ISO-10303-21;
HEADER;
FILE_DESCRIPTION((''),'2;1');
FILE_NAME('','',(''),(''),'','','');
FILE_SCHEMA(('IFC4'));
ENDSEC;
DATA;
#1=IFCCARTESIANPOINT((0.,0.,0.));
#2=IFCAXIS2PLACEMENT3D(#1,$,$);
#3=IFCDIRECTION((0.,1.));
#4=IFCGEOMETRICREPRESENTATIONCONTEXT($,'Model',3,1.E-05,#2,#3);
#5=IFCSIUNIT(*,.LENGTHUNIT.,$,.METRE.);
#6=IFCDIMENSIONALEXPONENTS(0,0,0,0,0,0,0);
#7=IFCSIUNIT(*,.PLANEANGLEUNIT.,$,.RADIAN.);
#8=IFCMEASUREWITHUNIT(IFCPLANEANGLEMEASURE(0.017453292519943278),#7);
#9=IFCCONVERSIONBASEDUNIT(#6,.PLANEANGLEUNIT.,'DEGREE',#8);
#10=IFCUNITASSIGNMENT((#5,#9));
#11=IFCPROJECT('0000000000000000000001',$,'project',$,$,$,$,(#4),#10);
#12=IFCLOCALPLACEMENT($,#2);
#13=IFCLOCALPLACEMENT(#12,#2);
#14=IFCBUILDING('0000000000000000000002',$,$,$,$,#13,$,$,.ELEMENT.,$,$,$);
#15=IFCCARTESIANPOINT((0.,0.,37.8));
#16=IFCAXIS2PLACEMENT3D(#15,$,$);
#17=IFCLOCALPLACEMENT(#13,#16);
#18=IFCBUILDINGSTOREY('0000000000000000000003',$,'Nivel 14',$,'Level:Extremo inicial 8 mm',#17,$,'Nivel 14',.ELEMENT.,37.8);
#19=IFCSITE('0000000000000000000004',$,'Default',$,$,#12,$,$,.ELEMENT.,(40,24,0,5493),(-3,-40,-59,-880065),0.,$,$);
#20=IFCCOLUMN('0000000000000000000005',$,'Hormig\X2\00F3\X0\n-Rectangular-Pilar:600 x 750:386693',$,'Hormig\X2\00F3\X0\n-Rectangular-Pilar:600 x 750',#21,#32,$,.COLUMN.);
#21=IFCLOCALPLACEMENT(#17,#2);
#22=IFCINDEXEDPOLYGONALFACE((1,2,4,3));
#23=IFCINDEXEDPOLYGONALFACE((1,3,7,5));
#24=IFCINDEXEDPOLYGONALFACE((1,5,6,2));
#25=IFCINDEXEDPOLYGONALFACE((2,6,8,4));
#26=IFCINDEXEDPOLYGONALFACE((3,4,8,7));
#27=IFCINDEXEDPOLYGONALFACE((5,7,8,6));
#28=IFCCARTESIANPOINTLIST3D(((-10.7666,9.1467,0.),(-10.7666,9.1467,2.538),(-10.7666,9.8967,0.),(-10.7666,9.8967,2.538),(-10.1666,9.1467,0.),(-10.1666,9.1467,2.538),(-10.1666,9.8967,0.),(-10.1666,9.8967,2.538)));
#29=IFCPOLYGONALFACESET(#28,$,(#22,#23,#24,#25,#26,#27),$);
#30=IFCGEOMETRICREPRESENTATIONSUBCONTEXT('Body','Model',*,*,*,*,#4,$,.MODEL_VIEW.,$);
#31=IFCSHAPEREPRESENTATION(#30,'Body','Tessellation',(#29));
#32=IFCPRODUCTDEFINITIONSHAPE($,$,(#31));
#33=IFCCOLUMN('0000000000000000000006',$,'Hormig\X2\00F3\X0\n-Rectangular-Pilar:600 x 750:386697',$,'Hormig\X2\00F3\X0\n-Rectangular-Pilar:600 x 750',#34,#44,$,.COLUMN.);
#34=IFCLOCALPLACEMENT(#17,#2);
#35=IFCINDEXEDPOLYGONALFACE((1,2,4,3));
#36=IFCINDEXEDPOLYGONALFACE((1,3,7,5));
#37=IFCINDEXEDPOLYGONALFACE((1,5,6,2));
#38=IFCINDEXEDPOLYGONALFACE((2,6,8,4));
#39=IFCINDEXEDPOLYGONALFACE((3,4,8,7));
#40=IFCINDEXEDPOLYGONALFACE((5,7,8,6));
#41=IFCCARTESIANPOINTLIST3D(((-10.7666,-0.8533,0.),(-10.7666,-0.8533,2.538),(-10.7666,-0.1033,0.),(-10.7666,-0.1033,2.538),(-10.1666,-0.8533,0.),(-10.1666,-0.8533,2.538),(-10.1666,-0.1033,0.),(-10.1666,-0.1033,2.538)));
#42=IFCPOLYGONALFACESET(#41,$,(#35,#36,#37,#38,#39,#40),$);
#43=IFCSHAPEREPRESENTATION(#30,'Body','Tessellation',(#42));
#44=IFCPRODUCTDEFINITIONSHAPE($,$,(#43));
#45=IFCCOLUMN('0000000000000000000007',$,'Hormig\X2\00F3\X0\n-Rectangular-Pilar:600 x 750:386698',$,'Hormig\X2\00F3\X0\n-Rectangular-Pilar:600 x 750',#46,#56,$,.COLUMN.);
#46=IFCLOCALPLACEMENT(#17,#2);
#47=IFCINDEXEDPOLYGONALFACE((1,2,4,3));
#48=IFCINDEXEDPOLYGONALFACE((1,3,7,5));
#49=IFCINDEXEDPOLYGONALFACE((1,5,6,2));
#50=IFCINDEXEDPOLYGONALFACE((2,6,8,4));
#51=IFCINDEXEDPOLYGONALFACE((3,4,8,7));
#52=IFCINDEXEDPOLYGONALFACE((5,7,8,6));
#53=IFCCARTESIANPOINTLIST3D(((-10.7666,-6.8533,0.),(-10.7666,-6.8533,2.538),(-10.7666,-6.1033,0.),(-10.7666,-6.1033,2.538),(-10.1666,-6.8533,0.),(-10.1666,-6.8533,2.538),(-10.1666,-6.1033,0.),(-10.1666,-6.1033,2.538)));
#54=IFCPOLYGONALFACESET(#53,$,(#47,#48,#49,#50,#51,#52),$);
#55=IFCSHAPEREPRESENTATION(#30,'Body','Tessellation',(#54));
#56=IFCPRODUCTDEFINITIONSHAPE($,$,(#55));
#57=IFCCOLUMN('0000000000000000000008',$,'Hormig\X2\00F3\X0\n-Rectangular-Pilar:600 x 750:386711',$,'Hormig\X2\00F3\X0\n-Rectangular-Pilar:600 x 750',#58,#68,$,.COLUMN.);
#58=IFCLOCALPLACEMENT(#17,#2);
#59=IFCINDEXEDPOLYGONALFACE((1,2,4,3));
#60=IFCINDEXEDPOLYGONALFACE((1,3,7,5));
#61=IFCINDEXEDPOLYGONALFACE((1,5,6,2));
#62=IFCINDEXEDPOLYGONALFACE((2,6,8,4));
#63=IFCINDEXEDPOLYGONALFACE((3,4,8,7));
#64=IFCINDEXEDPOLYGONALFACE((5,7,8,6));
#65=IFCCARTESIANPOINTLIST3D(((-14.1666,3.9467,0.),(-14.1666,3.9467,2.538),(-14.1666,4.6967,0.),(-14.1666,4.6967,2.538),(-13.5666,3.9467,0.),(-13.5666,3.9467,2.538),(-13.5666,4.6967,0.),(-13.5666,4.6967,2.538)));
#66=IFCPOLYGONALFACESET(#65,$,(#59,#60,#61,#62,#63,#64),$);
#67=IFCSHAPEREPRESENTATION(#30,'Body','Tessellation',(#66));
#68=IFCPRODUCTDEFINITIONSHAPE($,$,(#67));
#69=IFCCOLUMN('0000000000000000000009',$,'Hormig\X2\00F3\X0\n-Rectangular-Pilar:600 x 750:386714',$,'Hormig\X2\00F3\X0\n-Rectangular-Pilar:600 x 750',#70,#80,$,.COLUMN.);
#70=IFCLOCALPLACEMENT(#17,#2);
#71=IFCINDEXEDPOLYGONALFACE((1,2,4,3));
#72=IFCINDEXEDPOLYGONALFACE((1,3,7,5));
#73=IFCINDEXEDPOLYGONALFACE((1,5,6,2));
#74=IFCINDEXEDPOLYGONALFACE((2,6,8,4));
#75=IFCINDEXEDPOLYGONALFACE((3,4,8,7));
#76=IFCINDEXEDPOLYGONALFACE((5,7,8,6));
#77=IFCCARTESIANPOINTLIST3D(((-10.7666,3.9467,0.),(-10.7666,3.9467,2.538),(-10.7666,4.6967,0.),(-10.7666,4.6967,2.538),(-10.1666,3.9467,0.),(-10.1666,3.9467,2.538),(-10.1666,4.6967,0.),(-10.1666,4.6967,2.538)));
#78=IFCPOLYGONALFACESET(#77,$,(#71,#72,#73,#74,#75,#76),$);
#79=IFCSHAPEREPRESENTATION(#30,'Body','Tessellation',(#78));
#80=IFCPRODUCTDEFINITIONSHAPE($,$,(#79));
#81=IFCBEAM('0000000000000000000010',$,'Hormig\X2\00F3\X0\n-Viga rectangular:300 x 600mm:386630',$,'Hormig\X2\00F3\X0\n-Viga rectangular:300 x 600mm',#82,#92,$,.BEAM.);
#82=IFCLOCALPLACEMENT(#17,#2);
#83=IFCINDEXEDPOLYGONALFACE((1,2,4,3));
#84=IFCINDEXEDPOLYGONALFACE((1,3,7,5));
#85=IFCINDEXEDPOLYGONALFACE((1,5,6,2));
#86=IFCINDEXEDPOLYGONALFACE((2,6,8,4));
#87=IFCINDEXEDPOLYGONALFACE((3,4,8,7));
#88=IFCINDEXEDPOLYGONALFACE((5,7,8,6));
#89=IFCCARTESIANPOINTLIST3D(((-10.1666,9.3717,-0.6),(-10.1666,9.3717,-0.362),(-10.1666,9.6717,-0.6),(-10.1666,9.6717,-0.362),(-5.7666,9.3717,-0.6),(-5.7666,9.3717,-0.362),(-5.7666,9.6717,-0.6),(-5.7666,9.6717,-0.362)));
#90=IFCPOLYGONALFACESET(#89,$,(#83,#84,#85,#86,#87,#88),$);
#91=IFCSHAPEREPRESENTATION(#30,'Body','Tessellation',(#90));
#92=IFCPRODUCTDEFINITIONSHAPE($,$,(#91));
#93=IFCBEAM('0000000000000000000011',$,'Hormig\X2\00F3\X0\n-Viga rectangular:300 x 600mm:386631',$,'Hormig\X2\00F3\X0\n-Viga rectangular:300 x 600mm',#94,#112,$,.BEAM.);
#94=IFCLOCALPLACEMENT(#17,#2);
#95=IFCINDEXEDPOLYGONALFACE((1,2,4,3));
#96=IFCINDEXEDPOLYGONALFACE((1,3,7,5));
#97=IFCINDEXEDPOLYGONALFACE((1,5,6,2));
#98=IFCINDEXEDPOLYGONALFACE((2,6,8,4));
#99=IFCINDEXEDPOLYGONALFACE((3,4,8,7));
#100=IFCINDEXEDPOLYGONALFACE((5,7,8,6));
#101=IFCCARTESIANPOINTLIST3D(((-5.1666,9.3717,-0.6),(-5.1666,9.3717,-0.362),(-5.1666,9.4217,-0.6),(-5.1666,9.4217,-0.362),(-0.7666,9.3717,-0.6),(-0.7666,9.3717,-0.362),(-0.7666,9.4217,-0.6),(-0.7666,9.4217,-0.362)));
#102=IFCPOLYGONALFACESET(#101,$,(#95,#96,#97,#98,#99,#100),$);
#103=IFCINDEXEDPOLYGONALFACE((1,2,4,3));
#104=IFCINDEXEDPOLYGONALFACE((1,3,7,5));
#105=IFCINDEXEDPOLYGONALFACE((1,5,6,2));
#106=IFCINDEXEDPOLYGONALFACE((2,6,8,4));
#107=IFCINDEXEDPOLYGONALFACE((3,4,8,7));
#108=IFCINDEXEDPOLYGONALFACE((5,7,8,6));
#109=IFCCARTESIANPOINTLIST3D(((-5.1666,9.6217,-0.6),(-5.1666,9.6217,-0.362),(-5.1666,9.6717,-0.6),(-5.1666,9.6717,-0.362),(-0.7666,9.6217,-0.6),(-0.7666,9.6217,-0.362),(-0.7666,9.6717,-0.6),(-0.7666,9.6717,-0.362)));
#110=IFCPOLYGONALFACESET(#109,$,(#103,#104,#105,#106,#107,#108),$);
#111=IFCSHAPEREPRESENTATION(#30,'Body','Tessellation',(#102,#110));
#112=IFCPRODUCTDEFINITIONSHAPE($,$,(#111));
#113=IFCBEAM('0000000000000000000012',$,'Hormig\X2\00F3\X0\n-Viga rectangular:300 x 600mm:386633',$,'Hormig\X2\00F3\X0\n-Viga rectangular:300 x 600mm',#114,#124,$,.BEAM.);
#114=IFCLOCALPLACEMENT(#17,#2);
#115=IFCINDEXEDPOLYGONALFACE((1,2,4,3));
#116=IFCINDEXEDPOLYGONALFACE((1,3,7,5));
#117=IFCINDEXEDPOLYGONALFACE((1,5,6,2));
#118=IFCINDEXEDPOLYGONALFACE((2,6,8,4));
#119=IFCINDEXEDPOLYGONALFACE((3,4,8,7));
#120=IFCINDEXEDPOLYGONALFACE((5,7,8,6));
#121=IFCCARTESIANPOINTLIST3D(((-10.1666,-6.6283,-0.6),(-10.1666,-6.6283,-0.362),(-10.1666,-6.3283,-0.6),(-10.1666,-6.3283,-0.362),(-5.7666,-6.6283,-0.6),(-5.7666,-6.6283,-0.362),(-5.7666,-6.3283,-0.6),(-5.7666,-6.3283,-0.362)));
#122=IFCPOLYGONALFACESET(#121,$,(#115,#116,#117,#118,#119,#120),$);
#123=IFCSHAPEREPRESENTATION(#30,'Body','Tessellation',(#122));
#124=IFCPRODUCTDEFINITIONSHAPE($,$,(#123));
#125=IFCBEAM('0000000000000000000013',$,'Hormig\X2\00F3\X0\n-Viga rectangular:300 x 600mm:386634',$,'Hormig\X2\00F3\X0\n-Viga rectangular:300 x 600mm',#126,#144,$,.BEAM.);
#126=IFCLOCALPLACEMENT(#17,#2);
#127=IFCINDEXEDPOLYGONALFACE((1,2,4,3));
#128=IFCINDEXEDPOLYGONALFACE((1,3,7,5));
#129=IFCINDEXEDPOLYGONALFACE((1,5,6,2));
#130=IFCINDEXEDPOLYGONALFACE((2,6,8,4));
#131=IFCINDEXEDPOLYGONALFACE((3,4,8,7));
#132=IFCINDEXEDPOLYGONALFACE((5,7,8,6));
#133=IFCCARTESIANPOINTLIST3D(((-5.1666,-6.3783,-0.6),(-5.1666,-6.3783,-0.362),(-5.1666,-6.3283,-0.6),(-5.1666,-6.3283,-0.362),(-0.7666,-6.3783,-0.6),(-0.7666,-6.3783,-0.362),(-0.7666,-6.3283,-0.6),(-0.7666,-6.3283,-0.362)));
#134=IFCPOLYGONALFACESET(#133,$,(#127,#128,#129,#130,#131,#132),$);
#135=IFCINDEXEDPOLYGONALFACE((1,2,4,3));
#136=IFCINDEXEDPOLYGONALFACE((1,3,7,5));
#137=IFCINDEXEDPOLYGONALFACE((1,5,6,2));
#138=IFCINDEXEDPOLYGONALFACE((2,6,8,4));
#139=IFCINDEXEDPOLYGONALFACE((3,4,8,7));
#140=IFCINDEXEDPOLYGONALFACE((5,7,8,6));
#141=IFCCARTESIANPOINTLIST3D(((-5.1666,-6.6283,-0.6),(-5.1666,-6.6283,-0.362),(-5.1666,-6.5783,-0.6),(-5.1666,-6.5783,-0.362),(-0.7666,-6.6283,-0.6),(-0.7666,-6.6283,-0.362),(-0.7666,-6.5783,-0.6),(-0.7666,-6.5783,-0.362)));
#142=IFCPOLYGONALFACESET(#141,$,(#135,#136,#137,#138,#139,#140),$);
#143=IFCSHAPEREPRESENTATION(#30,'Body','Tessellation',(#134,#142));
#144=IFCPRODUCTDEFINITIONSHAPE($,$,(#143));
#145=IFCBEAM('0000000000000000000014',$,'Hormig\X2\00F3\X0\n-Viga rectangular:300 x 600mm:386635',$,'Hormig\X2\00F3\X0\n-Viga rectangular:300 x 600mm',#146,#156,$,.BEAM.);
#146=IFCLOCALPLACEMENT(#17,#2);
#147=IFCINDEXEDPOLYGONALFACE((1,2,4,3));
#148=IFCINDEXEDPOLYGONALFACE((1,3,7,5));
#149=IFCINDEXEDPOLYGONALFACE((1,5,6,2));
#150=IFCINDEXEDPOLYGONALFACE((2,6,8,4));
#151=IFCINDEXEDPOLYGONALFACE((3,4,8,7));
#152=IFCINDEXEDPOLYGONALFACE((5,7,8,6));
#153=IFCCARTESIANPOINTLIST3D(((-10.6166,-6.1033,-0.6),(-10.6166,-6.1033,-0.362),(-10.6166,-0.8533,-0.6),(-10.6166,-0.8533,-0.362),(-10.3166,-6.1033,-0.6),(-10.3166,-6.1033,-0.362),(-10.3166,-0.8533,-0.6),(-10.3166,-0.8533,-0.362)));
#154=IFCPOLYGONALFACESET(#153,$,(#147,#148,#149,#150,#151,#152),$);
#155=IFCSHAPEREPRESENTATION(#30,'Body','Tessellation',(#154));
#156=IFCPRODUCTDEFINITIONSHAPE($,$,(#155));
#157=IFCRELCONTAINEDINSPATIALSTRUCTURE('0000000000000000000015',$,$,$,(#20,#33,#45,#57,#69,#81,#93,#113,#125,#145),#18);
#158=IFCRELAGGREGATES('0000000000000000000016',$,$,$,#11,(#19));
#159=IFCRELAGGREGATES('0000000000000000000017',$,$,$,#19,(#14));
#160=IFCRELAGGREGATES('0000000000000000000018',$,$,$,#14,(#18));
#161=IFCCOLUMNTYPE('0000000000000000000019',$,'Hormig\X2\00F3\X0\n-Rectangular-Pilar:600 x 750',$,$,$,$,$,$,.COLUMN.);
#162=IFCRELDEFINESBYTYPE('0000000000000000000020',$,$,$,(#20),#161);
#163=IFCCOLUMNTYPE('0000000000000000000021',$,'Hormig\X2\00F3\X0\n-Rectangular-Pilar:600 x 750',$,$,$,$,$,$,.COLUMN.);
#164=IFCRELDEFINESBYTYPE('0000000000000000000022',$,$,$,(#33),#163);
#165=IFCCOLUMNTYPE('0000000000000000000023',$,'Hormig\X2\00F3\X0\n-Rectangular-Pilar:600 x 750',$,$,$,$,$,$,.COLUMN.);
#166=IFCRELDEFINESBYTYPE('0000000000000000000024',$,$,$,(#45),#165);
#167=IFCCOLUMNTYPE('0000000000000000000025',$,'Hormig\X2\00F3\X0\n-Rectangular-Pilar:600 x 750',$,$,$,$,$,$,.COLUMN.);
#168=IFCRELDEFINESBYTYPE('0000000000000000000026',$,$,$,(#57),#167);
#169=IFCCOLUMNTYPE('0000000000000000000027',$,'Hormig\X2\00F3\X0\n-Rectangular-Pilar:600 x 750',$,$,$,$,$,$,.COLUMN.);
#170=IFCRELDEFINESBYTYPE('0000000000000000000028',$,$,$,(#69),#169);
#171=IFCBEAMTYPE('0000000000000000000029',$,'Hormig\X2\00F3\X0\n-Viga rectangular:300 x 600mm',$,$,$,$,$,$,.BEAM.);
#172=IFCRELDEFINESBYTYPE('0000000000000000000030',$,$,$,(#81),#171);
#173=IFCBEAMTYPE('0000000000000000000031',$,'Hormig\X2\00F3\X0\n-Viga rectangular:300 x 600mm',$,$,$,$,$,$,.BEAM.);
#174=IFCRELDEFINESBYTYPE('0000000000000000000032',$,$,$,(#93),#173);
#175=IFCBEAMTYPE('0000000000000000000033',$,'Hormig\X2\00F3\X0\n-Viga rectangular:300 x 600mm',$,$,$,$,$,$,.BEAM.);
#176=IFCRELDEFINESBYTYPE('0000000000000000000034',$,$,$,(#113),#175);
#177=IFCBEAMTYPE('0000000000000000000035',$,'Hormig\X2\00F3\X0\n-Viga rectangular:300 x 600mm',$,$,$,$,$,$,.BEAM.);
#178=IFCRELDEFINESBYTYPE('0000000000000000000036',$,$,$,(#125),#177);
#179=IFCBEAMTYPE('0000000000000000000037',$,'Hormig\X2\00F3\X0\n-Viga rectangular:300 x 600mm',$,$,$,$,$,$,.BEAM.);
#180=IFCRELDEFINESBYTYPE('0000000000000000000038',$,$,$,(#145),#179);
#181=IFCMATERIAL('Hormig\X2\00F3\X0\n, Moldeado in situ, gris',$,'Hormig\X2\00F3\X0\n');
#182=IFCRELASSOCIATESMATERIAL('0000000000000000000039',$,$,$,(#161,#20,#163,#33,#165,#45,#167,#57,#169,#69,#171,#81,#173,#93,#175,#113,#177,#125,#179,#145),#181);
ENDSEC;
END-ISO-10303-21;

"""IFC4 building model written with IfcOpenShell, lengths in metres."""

from ifc_helpers import new_model, entity, si_unit, converted_unit, direction, frame, origin, place, context, subcontext, project, spatial, indexed_curve, outline, extrude, source, transform, mapped, material, type_object, type_shapes, element, save


model = new_model("IFC4")

# Units and contexts
model_context = context("Model", 3, precision=1e-05, world=origin(), true_north=direction((0.0, 1.0)))
body_context = subcontext(model_context, "Body", "Model", "MODEL_VIEW")
ifc_project = project(units=[si_unit("LENGTHUNIT", "METRE"), converted_unit("PLANEANGLEUNIT", "DEGREE", entity("IfcPlaneAngleMeasure", 0.017453292519943278), si_unit("PLANEANGLEUNIT", "RADIAN"), dimensions=[0, 0, 0, 0, 0, 0, 0])], contexts=[model_context])

# Site, building, storey
site_placement = place(None, origin())
site = spatial("IfcSite", under=ifc_project, at=site_placement, Name="Default", CompositionType="ELEMENT", RefLatitude=(40, 24, 0, 5493), RefLongitude=(-3, -40, -59, -880065), RefElevation=0.0)
building_placement = place(site_placement, origin())
building = spatial("IfcBuilding", under=site, at=building_placement, CompositionType="ELEMENT")
storey_placement = place(building_placement, frame((0.0, 0.0, 37.8)))
storey = spatial("IfcBuildingStorey", under=building, at=storey_placement, Name="Nivel 14", ObjectType="Level:Extremo inicial 8 mm", LongName="Nivel 14", CompositionType="ELEMENT", Elevation=37.8)

# Columns
ifc_material_1 = material(Name="Hormigón, Moldeado in situ, gris", Category="Hormigón")
column_type_1 = type_object("IfcColumnType", Name="Hormigón-Rectangular-Pilar:600 x 750", PredefinedType="COLUMN", material=ifc_material_1)
shared_shape_1 = source(origin(), body_context, "Body", "SweptSolid", [
    extrude(outline(indexed_curve([(-0.3, -0.375), (0.3, -0.375), (0.3, 0.375), (-0.3, 0.375), (-0.3, -0.375)], self_intersect=False)), frame((-10.4666, 9.5217, 37.8), z_axis=(0.0, 0.0, 1.0), x_axis=(-1.0, 0.0, 0.0)), (0.0, 0.0, 1.0), 2.538),
])
type_shapes(column_type_1, [shared_shape_1])
column_1_placement = place(storey_placement, frame((0.0, 0.0, -37.8)))
element("IfcColumn", 1, at=column_1_placement, inside=storey, type_object=column_type_1, material=ifc_material_1, Name="Hormigón-Rectangular-Pilar:600 x 750:386693", ObjectType="Hormigón-Rectangular-Pilar:600 x 750", PredefinedType="COLUMN", context=body_context, shape_type="MappedRepresentation", body=[
    mapped(shared_shape_1, transform((0.0, 0.0, 0.0), scale=1.0)),
])
column_type_2 = type_object("IfcColumnType", Name="Hormigón-Rectangular-Pilar:600 x 750", PredefinedType="COLUMN", material=ifc_material_1)
shared_shape_2 = source(origin(), body_context, "Body", "SweptSolid", [
    extrude(outline(indexed_curve([(-0.3, -0.375), (0.3, -0.375), (0.3, 0.375), (-0.3, 0.375), (-0.3, -0.375)], self_intersect=False)), frame((-10.4666, -0.4783, 37.8), z_axis=(0.0, 0.0, 1.0), x_axis=(-1.0, 0.0, 0.0)), (0.0, 0.0, 1.0), 2.538),
])
type_shapes(column_type_2, [shared_shape_2])
column_2_placement = place(storey_placement, frame((0.0, 0.0, -37.8)))
element("IfcColumn", 2, at=column_2_placement, inside=storey, type_object=column_type_2, material=ifc_material_1, Name="Hormigón-Rectangular-Pilar:600 x 750:386697", ObjectType="Hormigón-Rectangular-Pilar:600 x 750", PredefinedType="COLUMN", context=body_context, shape_type="MappedRepresentation", body=[
    mapped(shared_shape_2, transform((0.0, 0.0, 0.0), scale=1.0)),
])
column_type_3 = type_object("IfcColumnType", Name="Hormigón-Rectangular-Pilar:600 x 750", PredefinedType="COLUMN", material=ifc_material_1)
shared_shape_3 = source(origin(), body_context, "Body", "SweptSolid", [
    extrude(outline(indexed_curve([(-0.3, -0.375), (0.3, -0.375), (0.3, 0.375), (-0.3, 0.375), (-0.3, -0.375)], self_intersect=False)), frame((-10.4666, -6.4783, 37.8), z_axis=(0.0, 0.0, 1.0), x_axis=(-1.0, 0.0, 0.0)), (0.0, 0.0, 1.0), 2.538),
])
type_shapes(column_type_3, [shared_shape_3])
column_3_placement = place(storey_placement, frame((0.0, 0.0, -37.8)))
element("IfcColumn", 3, at=column_3_placement, inside=storey, type_object=column_type_3, material=ifc_material_1, Name="Hormigón-Rectangular-Pilar:600 x 750:386698", ObjectType="Hormigón-Rectangular-Pilar:600 x 750", PredefinedType="COLUMN", context=body_context, shape_type="MappedRepresentation", body=[
    mapped(shared_shape_3, transform((0.0, 0.0, 0.0), scale=1.0)),
])
column_type_4 = type_object("IfcColumnType", Name="Hormigón-Rectangular-Pilar:600 x 750", PredefinedType="COLUMN", material=ifc_material_1)
shared_shape_4 = source(origin(), body_context, "Body", "SweptSolid", [
    extrude(outline(indexed_curve([(-0.3, -0.375), (0.3, -0.375), (0.3, 0.375), (-0.3, 0.375), (-0.3, -0.375)], self_intersect=False)), frame((-13.8666, 4.3217, 37.8), z_axis=(0.0, 0.0, 1.0), x_axis=(-1.0, 0.0, 0.0)), (0.0, 0.0, 1.0), 2.538),
])
type_shapes(column_type_4, [shared_shape_4])
column_4_placement = place(storey_placement, frame((0.0, 0.0, -37.8)))
element("IfcColumn", 4, at=column_4_placement, inside=storey, type_object=column_type_4, material=ifc_material_1, Name="Hormigón-Rectangular-Pilar:600 x 750:386711", ObjectType="Hormigón-Rectangular-Pilar:600 x 750", PredefinedType="COLUMN", context=body_context, shape_type="MappedRepresentation", body=[
    mapped(shared_shape_4, transform((0.0, 0.0, 0.0), scale=1.0)),
])
column_type_5 = type_object("IfcColumnType", Name="Hormigón-Rectangular-Pilar:600 x 750", PredefinedType="COLUMN", material=ifc_material_1)
shared_shape_5 = source(origin(), body_context, "Body", "SweptSolid", [
    extrude(outline(indexed_curve([(-0.3, -0.375), (0.3, -0.375), (0.3, 0.375), (-0.3, 0.375), (-0.3, -0.375)], self_intersect=False)), frame((-10.4666, 4.3217, 37.8), z_axis=(0.0, 0.0, 1.0), x_axis=(-1.0, 0.0, 0.0)), (0.0, 0.0, 1.0), 2.538),
])
type_shapes(column_type_5, [shared_shape_5])
column_5_placement = place(storey_placement, frame((0.0, 0.0, -37.8)))
element("IfcColumn", 5, at=column_5_placement, inside=storey, type_object=column_type_5, material=ifc_material_1, Name="Hormigón-Rectangular-Pilar:600 x 750:386714", ObjectType="Hormigón-Rectangular-Pilar:600 x 750", PredefinedType="COLUMN", context=body_context, shape_type="MappedRepresentation", body=[
    mapped(shared_shape_5, transform((0.0, 0.0, 0.0), scale=1.0)),
])

# Beams
beam_type_1 = type_object("IfcBeamType", Name="Hormigón-Viga rectangular:300 x 600mm", PredefinedType="BEAM", material=ifc_material_1)
shared_shape_6 = source(origin(), body_context, "Body", "SweptSolid", [
    extrude(outline(indexed_curve([(-0.119, -0.15), (0.119, -0.15), (0.119, 0.15), (-0.119, 0.15), (-0.119, -0.15)], self_intersect=False)), frame((-5.7666, 9.5217, 37.319), z_axis=(-1.0, 0.0, 0.0), x_axis=(0.0, 0.0, -1.0)), (0.0, 0.0, 1.0), 4.4),
])
type_shapes(beam_type_1, [shared_shape_6])
beam_1_placement = place(storey_placement, frame((0.0, 0.0, -37.8)))
element("IfcBeam", 6, at=beam_1_placement, inside=storey, type_object=beam_type_1, material=ifc_material_1, Name="Hormigón-Viga rectangular:300 x 600mm:386630", ObjectType="Hormigón-Viga rectangular:300 x 600mm", PredefinedType="BEAM", context=body_context, shape_type="MappedRepresentation", body=[
    mapped(shared_shape_6, transform((0.0, 0.0, 0.0), scale=1.0)),
])
beam_type_2 = type_object("IfcBeamType", Name="Hormigón-Viga rectangular:300 x 600mm", PredefinedType="BEAM", material=ifc_material_1)
shared_shape_7 = source(origin(), body_context, "Body", "SweptSolid", [
    extrude(outline(indexed_curve([(-0.119, -0.025), (0.119, -0.025), (0.119, 0.025), (-0.119, 0.025), (-0.119, -0.025)], self_intersect=False)), frame((-5.1666, 9.3967, 37.319), z_axis=(1.0, 0.0, 0.0), x_axis=(0.0, 0.0, -1.0)), (0.0, 0.0, 1.0), 4.4),
    extrude(outline(indexed_curve([(-0.119, -0.025), (0.119, -0.025), (0.119, 0.025), (-0.119, 0.025), (-0.119, -0.025)], self_intersect=False)), frame((-5.1666, 9.6467, 37.319), z_axis=(1.0, 0.0, 0.0), x_axis=(0.0, 0.0, -1.0)), (0.0, 0.0, 1.0), 4.4),
])
type_shapes(beam_type_2, [shared_shape_7])
beam_2_placement = place(storey_placement, frame((0.0, 0.0, -37.8)))
element("IfcBeam", 7, at=beam_2_placement, inside=storey, type_object=beam_type_2, material=ifc_material_1, Name="Hormigón-Viga rectangular:300 x 600mm:386631", ObjectType="Hormigón-Viga rectangular:300 x 600mm", PredefinedType="BEAM", context=body_context, shape_type="MappedRepresentation", body=[
    mapped(shared_shape_7, transform((0.0, 0.0, 0.0), scale=1.0)),
])
beam_type_3 = type_object("IfcBeamType", Name="Hormigón-Viga rectangular:300 x 600mm", PredefinedType="BEAM", material=ifc_material_1)
shared_shape_8 = source(origin(), body_context, "Body", "SweptSolid", [
    extrude(outline(indexed_curve([(-0.119, -0.15), (0.119, -0.15), (0.119, 0.15), (-0.119, 0.15), (-0.119, -0.15)], self_intersect=False)), frame((-10.1666, -6.4783, 37.319), z_axis=(1.0, 0.0, 0.0), x_axis=(0.0, 0.0, -1.0)), (0.0, 0.0, 1.0), 4.4),
])
type_shapes(beam_type_3, [shared_shape_8])
beam_3_placement = place(storey_placement, frame((0.0, 0.0, -37.8)))
element("IfcBeam", 8, at=beam_3_placement, inside=storey, type_object=beam_type_3, material=ifc_material_1, Name="Hormigón-Viga rectangular:300 x 600mm:386633", ObjectType="Hormigón-Viga rectangular:300 x 600mm", PredefinedType="BEAM", context=body_context, shape_type="MappedRepresentation", body=[
    mapped(shared_shape_8, transform((0.0, 0.0, 0.0), scale=1.0)),
])
beam_type_4 = type_object("IfcBeamType", Name="Hormigón-Viga rectangular:300 x 600mm", PredefinedType="BEAM", material=ifc_material_1)
shared_shape_9 = source(origin(), body_context, "Body", "SweptSolid", [
    extrude(outline(indexed_curve([(-0.119, -0.025), (0.119, -0.025), (0.119, 0.025), (-0.119, 0.025), (-0.119, -0.025)], self_intersect=False)), frame((-0.7666, -6.3533, 37.319), z_axis=(-1.0, 0.0, 0.0), x_axis=(0.0, 0.0, -1.0)), (0.0, 0.0, 1.0), 4.4),
    extrude(outline(indexed_curve([(-0.119, -0.025), (0.119, -0.025), (0.119, 0.025), (-0.119, 0.025), (-0.119, -0.025)], self_intersect=False)), frame((-0.7666, -6.6033, 37.319), z_axis=(-1.0, 0.0, 0.0), x_axis=(0.0, 0.0, -1.0)), (0.0, 0.0, 1.0), 4.4),
])
type_shapes(beam_type_4, [shared_shape_9])
beam_4_placement = place(storey_placement, frame((0.0, 0.0, -37.8)))
element("IfcBeam", 9, at=beam_4_placement, inside=storey, type_object=beam_type_4, material=ifc_material_1, Name="Hormigón-Viga rectangular:300 x 600mm:386634", ObjectType="Hormigón-Viga rectangular:300 x 600mm", PredefinedType="BEAM", context=body_context, shape_type="MappedRepresentation", body=[
    mapped(shared_shape_9, transform((0.0, 0.0, 0.0), scale=1.0)),
])
beam_type_5 = type_object("IfcBeamType", Name="Hormigón-Viga rectangular:300 x 600mm", PredefinedType="BEAM", material=ifc_material_1)
shared_shape_10 = source(origin(), body_context, "Body", "SweptSolid", [
    extrude(outline(indexed_curve([(-0.15, -0.119), (0.15, -0.119), (0.15, 0.119), (-0.15, 0.119), (-0.15, -0.119)], self_intersect=False)), frame((-10.4666, -6.1033, 37.319), z_axis=(0.0, 1.0, 0.0), x_axis=(-1.0, 0.0, 0.0)), (0.0, 0.0, 1.0), 5.25),
])
type_shapes(beam_type_5, [shared_shape_10])
beam_5_placement = place(storey_placement, frame((0.0, 0.0, -37.8)))
element("IfcBeam", 10, at=beam_5_placement, inside=storey, type_object=beam_type_5, material=ifc_material_1, Name="Hormigón-Viga rectangular:300 x 600mm:386635", ObjectType="Hormigón-Viga rectangular:300 x 600mm", PredefinedType="BEAM", context=body_context, shape_type="MappedRepresentation", body=[
    mapped(shared_shape_10, transform((0.0, 0.0, 0.0), scale=1.0)),
])

save(model, "model.ifc")
